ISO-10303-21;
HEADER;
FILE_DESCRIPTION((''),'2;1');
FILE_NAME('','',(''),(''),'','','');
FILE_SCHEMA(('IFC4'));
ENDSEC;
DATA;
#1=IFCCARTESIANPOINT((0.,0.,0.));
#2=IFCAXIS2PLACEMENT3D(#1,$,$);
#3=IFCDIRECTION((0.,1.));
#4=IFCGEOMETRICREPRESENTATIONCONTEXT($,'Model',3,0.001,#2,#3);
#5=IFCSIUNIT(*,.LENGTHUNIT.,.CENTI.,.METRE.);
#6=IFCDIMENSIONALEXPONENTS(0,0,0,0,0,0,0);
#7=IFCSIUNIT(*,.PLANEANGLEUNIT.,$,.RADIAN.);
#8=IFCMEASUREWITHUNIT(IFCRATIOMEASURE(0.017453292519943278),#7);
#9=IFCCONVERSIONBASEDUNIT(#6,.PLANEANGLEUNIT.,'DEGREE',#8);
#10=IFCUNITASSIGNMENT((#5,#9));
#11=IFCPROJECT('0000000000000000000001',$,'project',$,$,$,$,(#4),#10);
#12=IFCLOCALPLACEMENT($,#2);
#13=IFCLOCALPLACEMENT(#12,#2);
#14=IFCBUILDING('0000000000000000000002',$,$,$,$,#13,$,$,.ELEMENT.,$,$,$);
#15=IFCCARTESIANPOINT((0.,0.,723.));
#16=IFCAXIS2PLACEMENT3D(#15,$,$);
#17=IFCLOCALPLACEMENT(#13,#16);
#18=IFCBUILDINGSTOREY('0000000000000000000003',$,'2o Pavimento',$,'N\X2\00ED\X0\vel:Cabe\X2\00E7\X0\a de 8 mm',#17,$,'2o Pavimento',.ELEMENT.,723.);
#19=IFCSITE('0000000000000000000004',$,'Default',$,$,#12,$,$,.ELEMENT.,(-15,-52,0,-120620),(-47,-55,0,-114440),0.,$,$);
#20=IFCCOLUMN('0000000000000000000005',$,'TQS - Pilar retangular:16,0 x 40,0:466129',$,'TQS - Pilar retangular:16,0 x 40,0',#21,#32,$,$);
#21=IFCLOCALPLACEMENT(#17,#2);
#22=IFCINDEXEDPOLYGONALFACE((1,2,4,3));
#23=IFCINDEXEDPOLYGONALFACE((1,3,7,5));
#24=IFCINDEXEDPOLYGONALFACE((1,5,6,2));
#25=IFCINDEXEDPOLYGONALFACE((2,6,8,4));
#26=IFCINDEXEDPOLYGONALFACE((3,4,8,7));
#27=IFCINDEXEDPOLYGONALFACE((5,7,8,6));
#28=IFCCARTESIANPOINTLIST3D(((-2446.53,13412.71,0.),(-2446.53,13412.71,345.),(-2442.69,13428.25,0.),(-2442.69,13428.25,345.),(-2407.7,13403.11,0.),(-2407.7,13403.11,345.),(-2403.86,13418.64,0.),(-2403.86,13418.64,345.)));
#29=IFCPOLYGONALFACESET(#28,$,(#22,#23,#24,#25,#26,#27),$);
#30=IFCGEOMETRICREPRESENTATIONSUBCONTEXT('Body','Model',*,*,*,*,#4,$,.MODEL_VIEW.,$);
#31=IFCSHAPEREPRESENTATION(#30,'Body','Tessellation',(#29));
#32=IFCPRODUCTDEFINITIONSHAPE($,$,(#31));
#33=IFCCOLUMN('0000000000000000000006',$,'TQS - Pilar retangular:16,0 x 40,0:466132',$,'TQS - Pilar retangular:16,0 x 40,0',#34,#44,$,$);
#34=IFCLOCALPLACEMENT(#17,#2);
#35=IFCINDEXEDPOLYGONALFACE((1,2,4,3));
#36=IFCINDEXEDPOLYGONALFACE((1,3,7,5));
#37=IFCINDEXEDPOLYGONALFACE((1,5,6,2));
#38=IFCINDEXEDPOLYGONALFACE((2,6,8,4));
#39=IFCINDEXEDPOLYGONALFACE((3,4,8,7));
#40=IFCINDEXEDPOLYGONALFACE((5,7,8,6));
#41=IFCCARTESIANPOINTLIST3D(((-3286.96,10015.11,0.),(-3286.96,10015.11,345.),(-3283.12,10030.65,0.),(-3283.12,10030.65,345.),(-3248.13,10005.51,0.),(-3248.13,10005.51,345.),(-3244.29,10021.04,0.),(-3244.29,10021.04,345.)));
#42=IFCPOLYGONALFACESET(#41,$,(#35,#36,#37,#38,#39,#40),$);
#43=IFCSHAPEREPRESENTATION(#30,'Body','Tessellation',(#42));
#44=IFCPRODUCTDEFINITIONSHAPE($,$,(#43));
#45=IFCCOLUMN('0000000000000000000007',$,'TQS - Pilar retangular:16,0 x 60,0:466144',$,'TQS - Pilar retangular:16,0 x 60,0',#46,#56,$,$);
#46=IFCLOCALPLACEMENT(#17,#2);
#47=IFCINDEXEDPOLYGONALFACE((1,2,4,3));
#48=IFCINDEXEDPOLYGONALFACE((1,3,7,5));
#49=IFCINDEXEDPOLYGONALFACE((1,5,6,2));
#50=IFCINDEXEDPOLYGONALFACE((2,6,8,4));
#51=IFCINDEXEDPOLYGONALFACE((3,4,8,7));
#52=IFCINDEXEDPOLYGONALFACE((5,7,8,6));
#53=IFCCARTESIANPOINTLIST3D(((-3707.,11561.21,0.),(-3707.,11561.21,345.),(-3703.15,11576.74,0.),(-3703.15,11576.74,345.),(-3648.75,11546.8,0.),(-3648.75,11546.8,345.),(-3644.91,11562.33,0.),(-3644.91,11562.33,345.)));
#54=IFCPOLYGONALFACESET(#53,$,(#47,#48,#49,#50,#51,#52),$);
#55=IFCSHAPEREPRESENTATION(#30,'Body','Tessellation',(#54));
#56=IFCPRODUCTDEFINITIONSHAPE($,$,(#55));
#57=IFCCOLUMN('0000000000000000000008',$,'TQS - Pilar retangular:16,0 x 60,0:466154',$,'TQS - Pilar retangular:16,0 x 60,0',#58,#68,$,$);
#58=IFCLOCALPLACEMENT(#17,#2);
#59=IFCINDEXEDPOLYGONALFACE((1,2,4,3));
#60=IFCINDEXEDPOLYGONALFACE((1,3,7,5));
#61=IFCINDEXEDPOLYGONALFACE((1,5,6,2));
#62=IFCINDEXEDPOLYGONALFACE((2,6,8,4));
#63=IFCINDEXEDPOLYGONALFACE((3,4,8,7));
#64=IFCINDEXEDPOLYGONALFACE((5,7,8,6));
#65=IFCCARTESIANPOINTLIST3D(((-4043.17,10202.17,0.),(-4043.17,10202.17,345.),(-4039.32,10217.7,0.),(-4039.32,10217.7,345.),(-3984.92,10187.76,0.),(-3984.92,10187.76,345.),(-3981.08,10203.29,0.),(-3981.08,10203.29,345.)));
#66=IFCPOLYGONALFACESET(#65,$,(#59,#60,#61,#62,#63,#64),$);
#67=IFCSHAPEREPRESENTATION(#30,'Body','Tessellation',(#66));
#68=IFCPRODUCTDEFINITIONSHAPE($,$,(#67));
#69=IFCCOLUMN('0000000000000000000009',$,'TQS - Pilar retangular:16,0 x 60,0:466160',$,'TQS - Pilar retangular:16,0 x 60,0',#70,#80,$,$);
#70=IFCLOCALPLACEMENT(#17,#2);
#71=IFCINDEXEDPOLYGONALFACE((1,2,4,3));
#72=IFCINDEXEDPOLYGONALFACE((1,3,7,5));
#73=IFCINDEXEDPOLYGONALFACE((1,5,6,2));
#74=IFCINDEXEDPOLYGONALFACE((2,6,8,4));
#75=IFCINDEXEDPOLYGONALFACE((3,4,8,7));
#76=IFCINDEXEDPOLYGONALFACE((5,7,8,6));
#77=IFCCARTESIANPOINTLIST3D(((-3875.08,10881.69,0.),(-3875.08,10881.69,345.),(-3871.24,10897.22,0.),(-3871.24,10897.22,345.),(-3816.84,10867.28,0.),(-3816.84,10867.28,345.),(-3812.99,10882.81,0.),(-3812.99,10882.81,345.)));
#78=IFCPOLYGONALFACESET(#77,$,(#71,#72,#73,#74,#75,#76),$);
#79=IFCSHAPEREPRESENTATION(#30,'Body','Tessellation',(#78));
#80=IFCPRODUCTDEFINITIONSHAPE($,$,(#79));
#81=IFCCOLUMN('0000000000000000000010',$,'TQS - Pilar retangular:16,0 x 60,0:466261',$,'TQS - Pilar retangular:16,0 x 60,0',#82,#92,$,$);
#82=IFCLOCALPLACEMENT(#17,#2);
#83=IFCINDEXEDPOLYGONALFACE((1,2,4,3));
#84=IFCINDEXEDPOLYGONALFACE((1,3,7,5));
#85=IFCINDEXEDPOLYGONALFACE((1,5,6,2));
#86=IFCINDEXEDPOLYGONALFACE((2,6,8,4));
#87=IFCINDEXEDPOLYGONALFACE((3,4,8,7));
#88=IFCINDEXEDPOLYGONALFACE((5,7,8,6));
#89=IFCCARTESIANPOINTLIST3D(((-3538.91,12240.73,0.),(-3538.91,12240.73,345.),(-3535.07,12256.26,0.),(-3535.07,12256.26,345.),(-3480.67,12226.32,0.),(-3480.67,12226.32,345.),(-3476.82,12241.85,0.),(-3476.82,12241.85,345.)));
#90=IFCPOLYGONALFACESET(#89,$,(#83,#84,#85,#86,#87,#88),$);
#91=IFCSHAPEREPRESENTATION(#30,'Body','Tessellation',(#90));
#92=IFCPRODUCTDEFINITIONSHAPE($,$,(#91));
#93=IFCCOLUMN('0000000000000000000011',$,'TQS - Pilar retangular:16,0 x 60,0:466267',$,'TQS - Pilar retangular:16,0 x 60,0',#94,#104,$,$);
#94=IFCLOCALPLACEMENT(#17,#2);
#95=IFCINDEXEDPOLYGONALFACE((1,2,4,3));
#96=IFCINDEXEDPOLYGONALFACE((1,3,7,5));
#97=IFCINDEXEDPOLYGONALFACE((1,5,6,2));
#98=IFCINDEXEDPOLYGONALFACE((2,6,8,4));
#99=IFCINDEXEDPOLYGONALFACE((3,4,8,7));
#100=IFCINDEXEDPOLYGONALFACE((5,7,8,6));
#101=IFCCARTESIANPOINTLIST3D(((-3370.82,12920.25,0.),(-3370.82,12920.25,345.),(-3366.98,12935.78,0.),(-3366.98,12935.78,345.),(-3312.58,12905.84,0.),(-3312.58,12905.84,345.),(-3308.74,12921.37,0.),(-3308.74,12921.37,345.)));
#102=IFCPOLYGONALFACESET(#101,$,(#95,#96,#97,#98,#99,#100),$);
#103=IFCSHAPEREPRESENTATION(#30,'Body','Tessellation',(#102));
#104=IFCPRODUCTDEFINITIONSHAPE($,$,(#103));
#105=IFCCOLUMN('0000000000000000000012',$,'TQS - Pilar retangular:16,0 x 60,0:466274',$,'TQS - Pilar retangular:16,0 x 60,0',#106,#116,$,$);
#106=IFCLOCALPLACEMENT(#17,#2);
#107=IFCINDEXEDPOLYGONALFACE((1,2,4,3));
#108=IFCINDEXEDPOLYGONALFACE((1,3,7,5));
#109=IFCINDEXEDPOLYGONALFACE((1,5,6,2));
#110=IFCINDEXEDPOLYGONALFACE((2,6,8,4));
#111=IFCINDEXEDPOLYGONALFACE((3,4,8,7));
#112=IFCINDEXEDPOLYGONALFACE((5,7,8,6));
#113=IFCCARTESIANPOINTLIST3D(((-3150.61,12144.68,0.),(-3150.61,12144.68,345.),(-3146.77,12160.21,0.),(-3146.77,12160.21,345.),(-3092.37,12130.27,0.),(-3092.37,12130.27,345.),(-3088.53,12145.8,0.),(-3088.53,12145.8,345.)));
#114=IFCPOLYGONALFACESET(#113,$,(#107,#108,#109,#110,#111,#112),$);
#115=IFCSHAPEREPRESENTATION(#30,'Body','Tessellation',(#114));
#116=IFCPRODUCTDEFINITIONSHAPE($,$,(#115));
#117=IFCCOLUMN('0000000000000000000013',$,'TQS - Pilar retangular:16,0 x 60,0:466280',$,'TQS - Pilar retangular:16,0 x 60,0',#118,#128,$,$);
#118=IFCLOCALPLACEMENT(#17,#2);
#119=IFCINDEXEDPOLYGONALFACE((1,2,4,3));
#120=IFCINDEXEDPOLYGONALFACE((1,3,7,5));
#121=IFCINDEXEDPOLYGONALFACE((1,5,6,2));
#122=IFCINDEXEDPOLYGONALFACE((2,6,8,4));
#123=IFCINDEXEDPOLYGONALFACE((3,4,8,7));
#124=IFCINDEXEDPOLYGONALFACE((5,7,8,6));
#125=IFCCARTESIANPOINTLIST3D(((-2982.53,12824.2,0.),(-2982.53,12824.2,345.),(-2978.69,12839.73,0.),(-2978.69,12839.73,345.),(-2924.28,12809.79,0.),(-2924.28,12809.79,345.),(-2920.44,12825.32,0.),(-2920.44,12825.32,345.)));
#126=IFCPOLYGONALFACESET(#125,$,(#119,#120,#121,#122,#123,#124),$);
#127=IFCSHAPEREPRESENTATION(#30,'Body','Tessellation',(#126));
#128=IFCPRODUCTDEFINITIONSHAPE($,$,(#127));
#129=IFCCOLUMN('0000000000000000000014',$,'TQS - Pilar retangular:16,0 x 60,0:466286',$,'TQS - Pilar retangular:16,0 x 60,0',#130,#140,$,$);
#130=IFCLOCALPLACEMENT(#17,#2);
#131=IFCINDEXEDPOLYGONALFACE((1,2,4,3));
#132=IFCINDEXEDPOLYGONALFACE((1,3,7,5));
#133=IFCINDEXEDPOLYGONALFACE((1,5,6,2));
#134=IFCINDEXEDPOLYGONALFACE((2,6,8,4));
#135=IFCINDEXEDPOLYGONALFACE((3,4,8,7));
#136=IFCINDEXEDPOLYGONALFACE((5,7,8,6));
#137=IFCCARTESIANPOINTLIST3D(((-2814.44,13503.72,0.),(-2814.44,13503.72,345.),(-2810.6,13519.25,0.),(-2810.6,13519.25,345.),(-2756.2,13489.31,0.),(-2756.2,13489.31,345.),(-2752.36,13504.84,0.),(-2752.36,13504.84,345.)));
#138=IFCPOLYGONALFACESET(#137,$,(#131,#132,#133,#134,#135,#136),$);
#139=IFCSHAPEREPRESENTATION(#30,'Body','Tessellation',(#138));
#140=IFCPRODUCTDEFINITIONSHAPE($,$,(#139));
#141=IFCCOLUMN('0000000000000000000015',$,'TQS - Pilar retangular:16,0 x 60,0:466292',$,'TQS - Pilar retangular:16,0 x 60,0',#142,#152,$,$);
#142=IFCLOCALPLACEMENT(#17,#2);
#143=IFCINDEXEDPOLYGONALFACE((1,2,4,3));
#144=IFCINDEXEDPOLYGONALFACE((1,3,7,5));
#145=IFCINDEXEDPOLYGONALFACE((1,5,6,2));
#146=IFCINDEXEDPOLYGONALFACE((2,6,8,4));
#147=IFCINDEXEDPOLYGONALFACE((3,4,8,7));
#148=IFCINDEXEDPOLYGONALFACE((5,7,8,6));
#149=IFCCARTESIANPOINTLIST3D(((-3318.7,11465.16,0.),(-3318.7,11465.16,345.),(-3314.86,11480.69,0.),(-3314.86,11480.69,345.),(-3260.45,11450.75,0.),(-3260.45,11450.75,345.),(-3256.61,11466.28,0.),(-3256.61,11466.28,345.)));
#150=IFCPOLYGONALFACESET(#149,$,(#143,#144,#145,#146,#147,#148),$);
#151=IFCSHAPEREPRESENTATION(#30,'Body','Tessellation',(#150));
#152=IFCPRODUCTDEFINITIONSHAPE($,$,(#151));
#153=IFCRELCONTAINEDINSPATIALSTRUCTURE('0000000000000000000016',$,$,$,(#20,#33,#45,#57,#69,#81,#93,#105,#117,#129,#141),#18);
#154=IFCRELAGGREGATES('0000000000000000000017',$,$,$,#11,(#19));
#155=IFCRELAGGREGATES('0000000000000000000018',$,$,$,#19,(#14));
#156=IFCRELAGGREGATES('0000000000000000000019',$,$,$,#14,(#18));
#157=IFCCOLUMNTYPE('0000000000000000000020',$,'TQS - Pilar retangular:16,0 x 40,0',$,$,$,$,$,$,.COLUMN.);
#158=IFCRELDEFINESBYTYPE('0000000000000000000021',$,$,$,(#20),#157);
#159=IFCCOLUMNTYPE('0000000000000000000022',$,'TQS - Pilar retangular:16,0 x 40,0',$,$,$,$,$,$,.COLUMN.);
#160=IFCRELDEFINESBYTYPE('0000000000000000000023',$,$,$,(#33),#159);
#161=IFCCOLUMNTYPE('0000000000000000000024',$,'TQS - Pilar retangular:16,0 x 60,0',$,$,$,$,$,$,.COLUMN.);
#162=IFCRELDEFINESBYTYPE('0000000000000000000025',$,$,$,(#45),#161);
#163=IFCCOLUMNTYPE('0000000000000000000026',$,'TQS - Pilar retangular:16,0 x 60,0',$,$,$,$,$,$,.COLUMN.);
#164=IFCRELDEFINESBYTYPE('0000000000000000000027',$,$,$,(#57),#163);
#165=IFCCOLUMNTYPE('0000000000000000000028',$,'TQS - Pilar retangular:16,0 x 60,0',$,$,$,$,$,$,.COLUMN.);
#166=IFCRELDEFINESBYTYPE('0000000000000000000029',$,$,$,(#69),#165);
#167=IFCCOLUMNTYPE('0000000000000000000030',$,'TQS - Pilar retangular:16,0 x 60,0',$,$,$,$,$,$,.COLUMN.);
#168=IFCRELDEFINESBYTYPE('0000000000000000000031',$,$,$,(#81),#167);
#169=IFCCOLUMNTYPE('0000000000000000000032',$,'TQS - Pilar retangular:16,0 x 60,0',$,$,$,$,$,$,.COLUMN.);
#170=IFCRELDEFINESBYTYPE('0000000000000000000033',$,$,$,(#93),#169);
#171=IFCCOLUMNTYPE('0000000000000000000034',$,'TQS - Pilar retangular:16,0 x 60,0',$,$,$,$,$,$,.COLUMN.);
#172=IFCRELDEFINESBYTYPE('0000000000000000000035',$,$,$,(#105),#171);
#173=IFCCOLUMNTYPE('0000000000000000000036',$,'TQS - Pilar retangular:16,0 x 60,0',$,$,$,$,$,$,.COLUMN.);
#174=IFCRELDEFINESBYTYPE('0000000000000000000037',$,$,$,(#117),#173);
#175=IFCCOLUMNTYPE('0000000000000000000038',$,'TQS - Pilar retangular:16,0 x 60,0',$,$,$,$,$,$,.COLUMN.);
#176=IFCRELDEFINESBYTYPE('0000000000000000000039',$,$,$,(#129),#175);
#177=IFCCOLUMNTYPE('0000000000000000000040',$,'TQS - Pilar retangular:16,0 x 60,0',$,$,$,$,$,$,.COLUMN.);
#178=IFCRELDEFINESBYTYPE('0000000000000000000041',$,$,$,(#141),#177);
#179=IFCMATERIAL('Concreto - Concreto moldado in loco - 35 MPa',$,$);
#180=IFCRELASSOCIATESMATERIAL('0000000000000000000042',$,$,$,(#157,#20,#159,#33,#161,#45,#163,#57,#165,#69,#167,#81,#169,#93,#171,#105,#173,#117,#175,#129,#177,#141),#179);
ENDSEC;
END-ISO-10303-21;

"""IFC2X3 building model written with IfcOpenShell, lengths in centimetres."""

from ifc_helpers import new_model, entity, si_unit, converted_unit, direction, frame, origin, origin_2d_with_axis, place, context, subcontext, project, spatial, rectangle, extrude, source, transform, mapped, material, type_object, type_shapes, element, save


model = new_model("IFC2X3")

# Units and contexts
model_context = context("Model", 3, precision=0.001, world=origin(), true_north=direction((0.0, 1.0)))
body_context = subcontext(model_context, "Body", "Model", "MODEL_VIEW")
ifc_project = project(units=[si_unit("LENGTHUNIT", "METRE", prefix="CENTI"), converted_unit("PLANEANGLEUNIT", "DEGREE", entity("IfcRatioMeasure", 0.017453292519943278), si_unit("PLANEANGLEUNIT", "RADIAN"), dimensions=[0, 0, 0, 0, 0, 0, 0])], contexts=[model_context])

# Site, building, storey
site_placement = place(None, origin())
site = spatial("IfcSite", under=ifc_project, at=site_placement, Name="Default", CompositionType="ELEMENT", RefLatitude=(-15, -52, 0, -120620), RefLongitude=(-47, -55, 0, -114440), RefElevation=0.0)
building_placement = place(site_placement, origin())
building = spatial("IfcBuilding", under=site, at=building_placement, CompositionType="ELEMENT")
storey_placement = place(building_placement, frame((0.0, 0.0, 723.0)))
storey = spatial("IfcBuildingStorey", under=building, at=storey_placement, Name="2o Pavimento", ObjectType="Nível:Cabeça de 8 mm", LongName="2o Pavimento", CompositionType="ELEMENT", Elevation=723.0)

# Columns
ifc_material = material(Name="Concreto - Concreto moldado in loco - 35 MPa")
column_type_1 = type_object("IfcColumnType", Name="TQS - Pilar retangular:16,0 x 40,0", PredefinedType="COLUMN", material=ifc_material)
shared_shape_1 = source(origin(), body_context, "Body", "SweptSolid", [
    extrude(rectangle(XDim=40.0, YDim=16.0, at=origin_2d_with_axis()), frame((-2425.19, 13415.68, 723.0), z_axis=(0.0, 0.0, 1.0), x_axis=(-0.970743, 0.240122, 0.0)), (0.0, 0.0, 1.0), 345.0),
])
type_shapes(column_type_1, [shared_shape_1])
column_1_placement = place(storey_placement, frame((0.0, 0.0, -723.0)))
element("IfcColumn", 1, at=column_1_placement, inside=storey, type_object=column_type_1, material=ifc_material, Name="TQS - Pilar retangular:16,0 x 40,0:466129", ObjectType="TQS - Pilar retangular:16,0 x 40,0", context=body_context, shape_type="MappedRepresentation", body=[
    mapped(shared_shape_1, transform((0.0, 0.0, 0.0), scale=1.0)),
])
column_type_2 = type_object("IfcColumnType", Name="TQS - Pilar retangular:16,0 x 40,0", PredefinedType="COLUMN", material=ifc_material)
shared_shape_2 = source(origin(), body_context, "Body", "SweptSolid", [
    extrude(rectangle(XDim=40.0, YDim=16.0, at=origin_2d_with_axis()), frame((-3265.62, 10018.08, 723.0), z_axis=(0.0, 0.0, 1.0), x_axis=(-0.970743, 0.240122, 0.0)), (0.0, 0.0, 1.0), 345.0),
])
type_shapes(column_type_2, [shared_shape_2])
column_2_placement = place(storey_placement, frame((0.0, 0.0, -723.0)))
element("IfcColumn", 2, at=column_2_placement, inside=storey, type_object=column_type_2, material=ifc_material, Name="TQS - Pilar retangular:16,0 x 40,0:466132", ObjectType="TQS - Pilar retangular:16,0 x 40,0", context=body_context, shape_type="MappedRepresentation", body=[
    mapped(shared_shape_2, transform((0.0, 0.0, 0.0), scale=1.0)),
])
column_type_3 = type_object("IfcColumnType", Name="TQS - Pilar retangular:16,0 x 60,0", PredefinedType="COLUMN", material=ifc_material)
shared_shape_3 = source(origin(), body_context, "Body", "SweptSolid", [
    extrude(rectangle(XDim=60.0, YDim=16.0, at=origin_2d_with_axis()), frame((-3675.95, 11561.77, 723.0), z_axis=(0.0, 0.0, 1.0), x_axis=(-0.970743, 0.240122, 0.0)), (0.0, 0.0, 1.0), 345.0),
])
type_shapes(column_type_3, [shared_shape_3])
column_3_placement = place(storey_placement, frame((0.0, 0.0, -723.0)))
element("IfcColumn", 3, at=column_3_placement, inside=storey, type_object=column_type_3, material=ifc_material, Name="TQS - Pilar retangular:16,0 x 60,0:466144", ObjectType="TQS - Pilar retangular:16,0 x 60,0", context=body_context, shape_type="MappedRepresentation", body=[
    mapped(shared_shape_3, transform((0.0, 0.0, 0.0), scale=1.0)),
])
column_type_4 = type_object("IfcColumnType", Name="TQS - Pilar retangular:16,0 x 60,0", PredefinedType="COLUMN", material=ifc_material)
shared_shape_4 = source(origin(), body_context, "Body", "SweptSolid", [
    extrude(rectangle(XDim=60.0, YDim=16.0, at=origin_2d_with_axis()), frame((-4012.12, 10202.73, 723.0), z_axis=(0.0, 0.0, 1.0), x_axis=(-0.970743, 0.240122, 0.0)), (0.0, 0.0, 1.0), 345.0),
])
type_shapes(column_type_4, [shared_shape_4])
column_4_placement = place(storey_placement, frame((0.0, 0.0, -723.0)))
element("IfcColumn", 4, at=column_4_placement, inside=storey, type_object=column_type_4, material=ifc_material, Name="TQS - Pilar retangular:16,0 x 60,0:466154", ObjectType="TQS - Pilar retangular:16,0 x 60,0", context=body_context, shape_type="MappedRepresentation", body=[
    mapped(shared_shape_4, transform((0.0, 0.0, 0.0), scale=1.0)),
])
column_type_5 = type_object("IfcColumnType", Name="TQS - Pilar retangular:16,0 x 60,0", PredefinedType="COLUMN", material=ifc_material)
shared_shape_5 = source(origin(), body_context, "Body", "SweptSolid", [
    extrude(rectangle(XDim=60.0, YDim=16.0, at=origin_2d_with_axis()), frame((-3844.04, 10882.25, 723.0), z_axis=(0.0, 0.0, 1.0), x_axis=(-0.970743, 0.240122, 0.0)), (0.0, 0.0, 1.0), 345.0),
])
type_shapes(column_type_5, [shared_shape_5])
column_5_placement = place(storey_placement, frame((0.0, 0.0, -723.0)))
element("IfcColumn", 5, at=column_5_placement, inside=storey, type_object=column_type_5, material=ifc_material, Name="TQS - Pilar retangular:16,0 x 60,0:466160", ObjectType="TQS - Pilar retangular:16,0 x 60,0", context=body_context, shape_type="MappedRepresentation", body=[
    mapped(shared_shape_5, transform((0.0, 0.0, 0.0), scale=1.0)),
])
column_type_6 = type_object("IfcColumnType", Name="TQS - Pilar retangular:16,0 x 60,0", PredefinedType="COLUMN", material=ifc_material)
shared_shape_6 = source(origin(), body_context, "Body", "SweptSolid", [
    extrude(rectangle(XDim=60.0, YDim=16.0, at=origin_2d_with_axis()), frame((-3507.87, 12241.29, 723.0), z_axis=(0.0, 0.0, 1.0), x_axis=(-0.970743, 0.240122, 0.0)), (0.0, 0.0, 1.0), 345.0),
])
type_shapes(column_type_6, [shared_shape_6])
column_6_placement = place(storey_placement, frame((0.0, 0.0, -723.0)))
element("IfcColumn", 6, at=column_6_placement, inside=storey, type_object=column_type_6, material=ifc_material, Name="TQS - Pilar retangular:16,0 x 60,0:466261", ObjectType="TQS - Pilar retangular:16,0 x 60,0", context=body_context, shape_type="MappedRepresentation", body=[
    mapped(shared_shape_6, transform((0.0, 0.0, 0.0), scale=1.0)),
])
column_type_7 = type_object("IfcColumnType", Name="TQS - Pilar retangular:16,0 x 60,0", PredefinedType="COLUMN", material=ifc_material)
shared_shape_7 = source(origin(), body_context, "Body", "SweptSolid", [
    extrude(rectangle(XDim=60.0, YDim=16.0, at=origin_2d_with_axis()), frame((-3339.78, 12920.81, 723.0), z_axis=(0.0, 0.0, 1.0), x_axis=(-0.970743, 0.240122, 0.0)), (0.0, 0.0, 1.0), 345.0),
])
type_shapes(column_type_7, [shared_shape_7])
column_7_placement = place(storey_placement, frame((0.0, 0.0, -723.0)))
element("IfcColumn", 7, at=column_7_placement, inside=storey, type_object=column_type_7, material=ifc_material, Name="TQS - Pilar retangular:16,0 x 60,0:466267", ObjectType="TQS - Pilar retangular:16,0 x 60,0", context=body_context, shape_type="MappedRepresentation", body=[
    mapped(shared_shape_7, transform((0.0, 0.0, 0.0), scale=1.0)),
])
column_type_8 = type_object("IfcColumnType", Name="TQS - Pilar retangular:16,0 x 60,0", PredefinedType="COLUMN", material=ifc_material)
shared_shape_8 = source(origin(), body_context, "Body", "SweptSolid", [
    extrude(rectangle(XDim=60.0, YDim=16.0, at=origin_2d_with_axis()), frame((-3119.57, 12145.24, 723.0), z_axis=(0.0, 0.0, 1.0), x_axis=(-0.970743, 0.240122, 0.0)), (0.0, 0.0, 1.0), 345.0),
])
type_shapes(column_type_8, [shared_shape_8])
column_8_placement = place(storey_placement, frame((0.0, 0.0, -723.0)))
element("IfcColumn", 8, at=column_8_placement, inside=storey, type_object=column_type_8, material=ifc_material, Name="TQS - Pilar retangular:16,0 x 60,0:466274", ObjectType="TQS - Pilar retangular:16,0 x 60,0", context=body_context, shape_type="MappedRepresentation", body=[
    mapped(shared_shape_8, transform((0.0, 0.0, 0.0), scale=1.0)),
])
column_type_9 = type_object("IfcColumnType", Name="TQS - Pilar retangular:16,0 x 60,0", PredefinedType="COLUMN", material=ifc_material)
shared_shape_9 = source(origin(), body_context, "Body", "SweptSolid", [
    extrude(rectangle(XDim=60.0, YDim=16.0, at=origin_2d_with_axis()), frame((-2951.48, 12824.76, 723.0), z_axis=(0.0, 0.0, 1.0), x_axis=(-0.970743, 0.240122, 0.0)), (0.0, 0.0, 1.0), 345.0),
])
type_shapes(column_type_9, [shared_shape_9])
column_9_placement = place(storey_placement, frame((0.0, 0.0, -723.0)))
element("IfcColumn", 9, at=column_9_placement, inside=storey, type_object=column_type_9, material=ifc_material, Name="TQS - Pilar retangular:16,0 x 60,0:466280", ObjectType="TQS - Pilar retangular:16,0 x 60,0", context=body_context, shape_type="MappedRepresentation", body=[
    mapped(shared_shape_9, transform((0.0, 0.0, 0.0), scale=1.0)),
])
column_type_10 = type_object("IfcColumnType", Name="TQS - Pilar retangular:16,0 x 60,0", PredefinedType="COLUMN", material=ifc_material)
shared_shape_10 = source(origin(), body_context, "Body", "SweptSolid", [
    extrude(rectangle(XDim=60.0, YDim=16.0, at=origin_2d_with_axis()), frame((-2783.4, 13504.28, 723.0), z_axis=(0.0, 0.0, 1.0), x_axis=(-0.970743, 0.240122, 0.0)), (0.0, 0.0, 1.0), 345.0),
])
type_shapes(column_type_10, [shared_shape_10])
column_10_placement = place(storey_placement, frame((0.0, 0.0, -723.0)))
element("IfcColumn", 10, at=column_10_placement, inside=storey, type_object=column_type_10, material=ifc_material, Name="TQS - Pilar retangular:16,0 x 60,0:466286", ObjectType="TQS - Pilar retangular:16,0 x 60,0", context=body_context, shape_type="MappedRepresentation", body=[
    mapped(shared_shape_10, transform((0.0, 0.0, 0.0), scale=1.0)),
])
column_type_11 = type_object("IfcColumnType", Name="TQS - Pilar retangular:16,0 x 60,0", PredefinedType="COLUMN", material=ifc_material)
shared_shape_11 = source(origin(), body_context, "Body", "SweptSolid", [
    extrude(rectangle(XDim=60.0, YDim=16.0, at=origin_2d_with_axis()), frame((-3287.66, 11465.72, 723.0), z_axis=(0.0, 0.0, 1.0), x_axis=(-0.970743, 0.240122, 0.0)), (0.0, 0.0, 1.0), 345.0),
])
type_shapes(column_type_11, [shared_shape_11])
column_11_placement = place(storey_placement, frame((0.0, 0.0, -723.0)))
element("IfcColumn", 11, at=column_11_placement, inside=storey, type_object=column_type_11, material=ifc_material, Name="TQS - Pilar retangular:16,0 x 60,0:466292", ObjectType="TQS - Pilar retangular:16,0 x 60,0", context=body_context, shape_type="MappedRepresentation", body=[
    mapped(shared_shape_11, transform((0.0, 0.0, 0.0), scale=1.0)),
])

save(model, "model.ifc")
